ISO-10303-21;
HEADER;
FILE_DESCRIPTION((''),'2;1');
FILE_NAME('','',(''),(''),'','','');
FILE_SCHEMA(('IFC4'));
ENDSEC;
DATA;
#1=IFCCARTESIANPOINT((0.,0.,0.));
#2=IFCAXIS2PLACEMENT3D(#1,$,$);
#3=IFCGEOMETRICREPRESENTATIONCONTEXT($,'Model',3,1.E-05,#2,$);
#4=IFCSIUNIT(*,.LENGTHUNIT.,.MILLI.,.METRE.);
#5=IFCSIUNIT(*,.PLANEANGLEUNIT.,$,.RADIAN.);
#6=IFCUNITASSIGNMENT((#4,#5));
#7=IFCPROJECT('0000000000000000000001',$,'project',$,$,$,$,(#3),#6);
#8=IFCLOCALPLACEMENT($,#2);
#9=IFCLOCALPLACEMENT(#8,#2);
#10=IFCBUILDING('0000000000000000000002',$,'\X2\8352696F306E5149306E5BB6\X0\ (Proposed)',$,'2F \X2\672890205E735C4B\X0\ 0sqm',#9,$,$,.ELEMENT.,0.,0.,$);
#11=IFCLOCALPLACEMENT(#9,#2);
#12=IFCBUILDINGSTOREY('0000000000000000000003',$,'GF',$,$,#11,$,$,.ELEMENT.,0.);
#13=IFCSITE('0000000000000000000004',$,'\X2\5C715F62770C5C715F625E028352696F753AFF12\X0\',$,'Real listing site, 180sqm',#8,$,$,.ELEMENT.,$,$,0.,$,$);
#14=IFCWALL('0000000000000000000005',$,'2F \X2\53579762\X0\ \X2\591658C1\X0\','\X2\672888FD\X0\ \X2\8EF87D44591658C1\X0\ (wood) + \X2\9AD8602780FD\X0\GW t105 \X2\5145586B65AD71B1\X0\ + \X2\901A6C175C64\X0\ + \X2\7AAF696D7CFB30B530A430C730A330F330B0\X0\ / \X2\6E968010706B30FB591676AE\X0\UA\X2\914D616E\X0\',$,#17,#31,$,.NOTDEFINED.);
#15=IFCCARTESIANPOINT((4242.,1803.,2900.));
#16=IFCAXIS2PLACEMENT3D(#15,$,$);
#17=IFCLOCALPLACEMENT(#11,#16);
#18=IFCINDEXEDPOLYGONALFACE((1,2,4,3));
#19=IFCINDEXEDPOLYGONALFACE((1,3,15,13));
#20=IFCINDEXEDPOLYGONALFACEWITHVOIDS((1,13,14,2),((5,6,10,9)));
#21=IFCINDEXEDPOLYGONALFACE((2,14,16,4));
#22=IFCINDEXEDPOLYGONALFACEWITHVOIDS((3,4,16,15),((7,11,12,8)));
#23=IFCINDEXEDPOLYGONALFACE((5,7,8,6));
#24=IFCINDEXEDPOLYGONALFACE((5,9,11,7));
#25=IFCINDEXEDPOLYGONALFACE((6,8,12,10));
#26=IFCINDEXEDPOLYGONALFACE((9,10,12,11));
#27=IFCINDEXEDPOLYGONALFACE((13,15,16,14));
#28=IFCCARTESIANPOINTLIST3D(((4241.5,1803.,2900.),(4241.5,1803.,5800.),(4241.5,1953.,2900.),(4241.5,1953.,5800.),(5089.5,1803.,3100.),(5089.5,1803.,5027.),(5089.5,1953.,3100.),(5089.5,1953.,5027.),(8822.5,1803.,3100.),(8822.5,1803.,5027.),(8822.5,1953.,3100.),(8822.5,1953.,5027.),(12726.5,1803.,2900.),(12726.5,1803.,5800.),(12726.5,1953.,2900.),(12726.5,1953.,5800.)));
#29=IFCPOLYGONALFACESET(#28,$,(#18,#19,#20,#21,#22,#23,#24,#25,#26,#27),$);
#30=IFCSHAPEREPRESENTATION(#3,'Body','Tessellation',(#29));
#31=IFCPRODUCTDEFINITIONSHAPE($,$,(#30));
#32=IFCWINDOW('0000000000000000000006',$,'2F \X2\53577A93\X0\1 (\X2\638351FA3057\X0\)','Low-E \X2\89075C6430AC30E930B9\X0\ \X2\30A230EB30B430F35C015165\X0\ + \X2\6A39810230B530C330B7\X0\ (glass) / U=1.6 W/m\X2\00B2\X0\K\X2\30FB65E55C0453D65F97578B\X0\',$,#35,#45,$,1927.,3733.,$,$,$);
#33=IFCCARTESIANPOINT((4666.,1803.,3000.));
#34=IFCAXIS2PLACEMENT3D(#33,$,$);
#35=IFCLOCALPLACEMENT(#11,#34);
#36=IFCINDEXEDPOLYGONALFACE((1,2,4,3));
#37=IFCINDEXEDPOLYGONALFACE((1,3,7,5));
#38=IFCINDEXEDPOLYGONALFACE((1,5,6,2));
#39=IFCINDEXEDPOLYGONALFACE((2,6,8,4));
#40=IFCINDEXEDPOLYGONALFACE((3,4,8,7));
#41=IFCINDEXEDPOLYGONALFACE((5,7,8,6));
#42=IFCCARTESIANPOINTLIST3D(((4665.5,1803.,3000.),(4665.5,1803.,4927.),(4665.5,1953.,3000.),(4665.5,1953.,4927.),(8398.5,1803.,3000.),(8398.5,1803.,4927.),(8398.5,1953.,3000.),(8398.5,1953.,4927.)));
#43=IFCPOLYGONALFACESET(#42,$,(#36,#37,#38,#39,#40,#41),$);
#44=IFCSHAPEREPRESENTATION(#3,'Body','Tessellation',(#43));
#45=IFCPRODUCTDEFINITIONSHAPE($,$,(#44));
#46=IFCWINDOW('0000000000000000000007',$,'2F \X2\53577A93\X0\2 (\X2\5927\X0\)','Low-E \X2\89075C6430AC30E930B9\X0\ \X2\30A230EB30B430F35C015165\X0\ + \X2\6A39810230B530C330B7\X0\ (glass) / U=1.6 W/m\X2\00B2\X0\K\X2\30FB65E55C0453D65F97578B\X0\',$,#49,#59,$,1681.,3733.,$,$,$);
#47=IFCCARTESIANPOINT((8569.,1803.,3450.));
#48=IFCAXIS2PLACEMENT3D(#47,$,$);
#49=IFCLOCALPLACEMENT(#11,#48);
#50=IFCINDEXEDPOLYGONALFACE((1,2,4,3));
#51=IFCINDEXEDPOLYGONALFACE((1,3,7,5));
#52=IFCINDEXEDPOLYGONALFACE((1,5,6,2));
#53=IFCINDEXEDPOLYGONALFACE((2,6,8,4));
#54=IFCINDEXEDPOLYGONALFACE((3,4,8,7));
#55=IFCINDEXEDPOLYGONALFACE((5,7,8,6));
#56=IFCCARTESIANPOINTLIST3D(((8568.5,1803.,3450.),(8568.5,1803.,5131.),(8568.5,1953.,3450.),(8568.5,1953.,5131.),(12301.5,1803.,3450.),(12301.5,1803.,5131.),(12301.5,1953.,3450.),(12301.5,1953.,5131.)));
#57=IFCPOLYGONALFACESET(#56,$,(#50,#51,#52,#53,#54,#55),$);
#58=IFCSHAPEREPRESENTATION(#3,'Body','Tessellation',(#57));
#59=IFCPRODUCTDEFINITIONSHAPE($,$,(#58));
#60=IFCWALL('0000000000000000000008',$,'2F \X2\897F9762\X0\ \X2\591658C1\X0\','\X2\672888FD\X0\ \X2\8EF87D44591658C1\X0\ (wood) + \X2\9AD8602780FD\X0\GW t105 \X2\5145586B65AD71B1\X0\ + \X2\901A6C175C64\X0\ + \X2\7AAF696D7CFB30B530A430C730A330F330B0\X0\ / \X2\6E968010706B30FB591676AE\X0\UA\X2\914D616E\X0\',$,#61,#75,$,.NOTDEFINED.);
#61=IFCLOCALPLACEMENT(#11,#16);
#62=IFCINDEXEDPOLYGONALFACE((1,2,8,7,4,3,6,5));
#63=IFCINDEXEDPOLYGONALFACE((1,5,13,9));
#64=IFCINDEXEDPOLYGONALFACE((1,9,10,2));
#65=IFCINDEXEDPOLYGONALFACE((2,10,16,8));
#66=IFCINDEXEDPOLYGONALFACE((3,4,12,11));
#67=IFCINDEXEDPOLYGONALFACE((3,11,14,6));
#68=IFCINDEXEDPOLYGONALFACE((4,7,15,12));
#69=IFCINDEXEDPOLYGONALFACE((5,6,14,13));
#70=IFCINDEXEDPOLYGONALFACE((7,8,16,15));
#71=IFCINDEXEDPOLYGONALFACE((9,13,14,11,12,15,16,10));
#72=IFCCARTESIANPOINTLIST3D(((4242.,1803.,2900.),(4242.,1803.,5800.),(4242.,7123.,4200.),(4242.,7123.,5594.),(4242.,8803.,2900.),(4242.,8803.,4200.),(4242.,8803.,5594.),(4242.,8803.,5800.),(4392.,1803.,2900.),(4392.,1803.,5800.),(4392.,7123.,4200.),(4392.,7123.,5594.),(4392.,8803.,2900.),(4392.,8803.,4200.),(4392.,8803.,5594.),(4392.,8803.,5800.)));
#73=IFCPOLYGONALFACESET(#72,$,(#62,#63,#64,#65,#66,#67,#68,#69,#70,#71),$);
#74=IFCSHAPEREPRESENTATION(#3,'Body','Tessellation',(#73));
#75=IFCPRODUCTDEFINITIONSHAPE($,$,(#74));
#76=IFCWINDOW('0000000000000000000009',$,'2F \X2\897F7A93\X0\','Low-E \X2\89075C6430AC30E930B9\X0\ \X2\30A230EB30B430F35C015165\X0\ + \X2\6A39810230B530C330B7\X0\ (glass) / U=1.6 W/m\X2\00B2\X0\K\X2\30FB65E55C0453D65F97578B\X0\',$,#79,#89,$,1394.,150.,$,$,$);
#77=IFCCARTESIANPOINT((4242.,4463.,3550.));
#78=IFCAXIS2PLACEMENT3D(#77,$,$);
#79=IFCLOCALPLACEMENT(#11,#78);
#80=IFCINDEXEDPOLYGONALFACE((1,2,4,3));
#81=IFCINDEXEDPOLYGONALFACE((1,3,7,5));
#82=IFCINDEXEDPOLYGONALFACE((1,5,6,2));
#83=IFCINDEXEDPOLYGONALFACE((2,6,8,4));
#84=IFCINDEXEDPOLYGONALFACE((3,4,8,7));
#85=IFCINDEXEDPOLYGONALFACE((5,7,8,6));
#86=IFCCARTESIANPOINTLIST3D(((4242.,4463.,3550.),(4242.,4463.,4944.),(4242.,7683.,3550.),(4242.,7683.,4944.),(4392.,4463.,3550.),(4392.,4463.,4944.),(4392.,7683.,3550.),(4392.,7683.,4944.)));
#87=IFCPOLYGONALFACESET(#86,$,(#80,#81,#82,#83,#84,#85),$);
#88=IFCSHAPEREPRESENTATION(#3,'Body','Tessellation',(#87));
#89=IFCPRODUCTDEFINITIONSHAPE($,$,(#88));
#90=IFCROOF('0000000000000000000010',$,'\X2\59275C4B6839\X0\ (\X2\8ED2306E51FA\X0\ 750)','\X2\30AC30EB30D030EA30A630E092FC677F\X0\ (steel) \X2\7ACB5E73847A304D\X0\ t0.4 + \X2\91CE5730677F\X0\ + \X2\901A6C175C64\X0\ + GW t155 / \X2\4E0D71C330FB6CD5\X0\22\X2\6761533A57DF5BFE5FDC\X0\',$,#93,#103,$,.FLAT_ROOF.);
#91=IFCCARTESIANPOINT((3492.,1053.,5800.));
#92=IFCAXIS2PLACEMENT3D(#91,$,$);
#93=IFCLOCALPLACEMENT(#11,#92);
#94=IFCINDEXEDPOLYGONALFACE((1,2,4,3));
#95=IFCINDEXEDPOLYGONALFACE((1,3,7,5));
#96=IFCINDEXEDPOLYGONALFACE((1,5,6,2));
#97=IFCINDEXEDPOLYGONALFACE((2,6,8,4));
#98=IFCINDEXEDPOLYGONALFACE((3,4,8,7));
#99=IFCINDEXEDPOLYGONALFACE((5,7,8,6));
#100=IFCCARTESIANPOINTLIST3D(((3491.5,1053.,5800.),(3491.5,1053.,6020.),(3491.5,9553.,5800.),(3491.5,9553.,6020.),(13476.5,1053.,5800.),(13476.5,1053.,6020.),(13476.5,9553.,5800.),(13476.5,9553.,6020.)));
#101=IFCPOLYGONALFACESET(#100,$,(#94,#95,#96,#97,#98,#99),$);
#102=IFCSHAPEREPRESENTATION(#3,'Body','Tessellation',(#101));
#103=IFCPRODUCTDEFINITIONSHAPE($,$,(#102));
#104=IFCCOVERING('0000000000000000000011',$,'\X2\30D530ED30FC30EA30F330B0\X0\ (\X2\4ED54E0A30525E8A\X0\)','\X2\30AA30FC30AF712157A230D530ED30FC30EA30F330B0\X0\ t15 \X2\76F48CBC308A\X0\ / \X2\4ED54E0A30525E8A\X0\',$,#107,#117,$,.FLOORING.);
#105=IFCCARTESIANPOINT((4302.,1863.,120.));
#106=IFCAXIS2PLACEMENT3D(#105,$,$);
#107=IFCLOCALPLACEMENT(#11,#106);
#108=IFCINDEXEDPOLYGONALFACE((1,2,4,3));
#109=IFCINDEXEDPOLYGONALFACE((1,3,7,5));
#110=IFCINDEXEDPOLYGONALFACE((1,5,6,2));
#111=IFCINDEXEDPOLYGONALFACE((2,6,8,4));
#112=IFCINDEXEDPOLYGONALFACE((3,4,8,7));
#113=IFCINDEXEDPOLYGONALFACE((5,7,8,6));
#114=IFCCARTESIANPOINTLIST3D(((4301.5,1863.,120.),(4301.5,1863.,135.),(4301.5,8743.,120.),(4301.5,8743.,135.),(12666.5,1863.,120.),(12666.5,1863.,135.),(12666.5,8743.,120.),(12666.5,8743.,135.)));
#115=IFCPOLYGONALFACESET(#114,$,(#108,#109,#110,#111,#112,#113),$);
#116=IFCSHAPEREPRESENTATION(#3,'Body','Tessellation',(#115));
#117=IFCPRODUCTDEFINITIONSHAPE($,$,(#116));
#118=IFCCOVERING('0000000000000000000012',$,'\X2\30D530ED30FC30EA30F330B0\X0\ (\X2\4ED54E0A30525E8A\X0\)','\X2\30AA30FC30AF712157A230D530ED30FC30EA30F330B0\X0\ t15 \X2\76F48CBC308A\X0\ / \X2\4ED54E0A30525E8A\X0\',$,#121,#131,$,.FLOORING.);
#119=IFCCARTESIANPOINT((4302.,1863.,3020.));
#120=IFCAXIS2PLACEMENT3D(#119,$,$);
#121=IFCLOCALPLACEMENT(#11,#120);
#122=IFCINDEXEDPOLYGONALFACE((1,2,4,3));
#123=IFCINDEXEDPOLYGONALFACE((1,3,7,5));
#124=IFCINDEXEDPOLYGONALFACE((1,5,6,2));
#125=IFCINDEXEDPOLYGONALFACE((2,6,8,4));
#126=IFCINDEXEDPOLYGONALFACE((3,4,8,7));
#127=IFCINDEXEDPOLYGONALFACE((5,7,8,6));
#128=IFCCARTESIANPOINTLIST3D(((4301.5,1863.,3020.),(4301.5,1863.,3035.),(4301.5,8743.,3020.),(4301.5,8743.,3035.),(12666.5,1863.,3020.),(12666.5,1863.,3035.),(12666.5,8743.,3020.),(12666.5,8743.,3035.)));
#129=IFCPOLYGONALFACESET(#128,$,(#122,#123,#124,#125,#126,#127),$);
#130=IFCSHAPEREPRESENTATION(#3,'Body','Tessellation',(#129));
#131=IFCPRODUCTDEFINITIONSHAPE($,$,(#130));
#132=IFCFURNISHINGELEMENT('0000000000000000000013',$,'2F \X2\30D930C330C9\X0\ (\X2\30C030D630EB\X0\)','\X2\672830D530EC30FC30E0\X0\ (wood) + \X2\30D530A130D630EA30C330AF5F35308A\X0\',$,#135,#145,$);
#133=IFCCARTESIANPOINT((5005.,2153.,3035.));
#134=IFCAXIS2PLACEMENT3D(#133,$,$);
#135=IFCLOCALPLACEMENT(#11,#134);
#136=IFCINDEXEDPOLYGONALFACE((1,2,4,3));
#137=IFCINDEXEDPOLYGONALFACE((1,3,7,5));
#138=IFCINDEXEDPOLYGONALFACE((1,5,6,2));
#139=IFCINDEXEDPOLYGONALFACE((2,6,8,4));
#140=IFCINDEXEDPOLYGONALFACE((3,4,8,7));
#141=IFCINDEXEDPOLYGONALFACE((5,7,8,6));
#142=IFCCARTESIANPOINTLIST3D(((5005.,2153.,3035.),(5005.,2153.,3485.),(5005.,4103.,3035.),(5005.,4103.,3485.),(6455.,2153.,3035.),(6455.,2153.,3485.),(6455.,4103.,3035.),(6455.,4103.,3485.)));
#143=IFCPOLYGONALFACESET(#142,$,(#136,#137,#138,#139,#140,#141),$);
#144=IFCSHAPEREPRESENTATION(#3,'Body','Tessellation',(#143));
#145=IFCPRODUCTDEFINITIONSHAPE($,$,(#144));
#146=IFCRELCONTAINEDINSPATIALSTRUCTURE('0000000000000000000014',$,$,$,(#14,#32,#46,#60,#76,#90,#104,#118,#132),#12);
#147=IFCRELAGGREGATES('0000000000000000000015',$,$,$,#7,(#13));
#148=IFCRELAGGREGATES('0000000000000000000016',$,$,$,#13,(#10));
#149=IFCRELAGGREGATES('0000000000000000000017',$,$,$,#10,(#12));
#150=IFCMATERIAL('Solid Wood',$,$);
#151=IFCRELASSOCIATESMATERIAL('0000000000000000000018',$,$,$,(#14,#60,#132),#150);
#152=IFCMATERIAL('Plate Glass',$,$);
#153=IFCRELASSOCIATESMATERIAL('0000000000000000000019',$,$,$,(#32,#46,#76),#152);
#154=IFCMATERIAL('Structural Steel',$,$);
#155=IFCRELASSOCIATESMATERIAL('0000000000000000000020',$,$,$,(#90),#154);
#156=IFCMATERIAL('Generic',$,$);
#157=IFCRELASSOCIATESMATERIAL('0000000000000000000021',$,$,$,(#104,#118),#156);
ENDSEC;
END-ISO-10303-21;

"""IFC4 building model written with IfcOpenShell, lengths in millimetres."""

from ifc_helpers import new_model, si_unit, frame, frame_2d, origin, place, context, project, spatial, rectangle, extrude, material, element, fill, save


model = new_model("IFC4")

# Units and contexts
model_context = context("Model", 3, precision=1e-05, world=origin())
ifc_project = project(units=[si_unit("LENGTHUNIT", "METRE", prefix="MILLI"), si_unit("PLANEANGLEUNIT", "RADIAN")], contexts=[model_context])

# Site, building, storey
site_placement = place(None, origin())
site = spatial("IfcSite", under=ifc_project, at=site_placement, Name="山形県山形市荒楯町２", ObjectType="Real listing site, 180sqm", CompositionType="ELEMENT", RefElevation=0.0)
building_placement = place(site_placement, origin())
building = spatial("IfcBuilding", under=site, at=building_placement, Name="荒楯の光の家 (Proposed)", ObjectType="2F 木造平屋 0sqm", CompositionType="ELEMENT", ElevationOfRefHeight=0.0, ElevationOfTerrain=0.0)
storey_placement = place(building_placement, origin())
storey = spatial("IfcBuildingStorey", under=building, at=storey_placement, Name="GF", CompositionType="ELEMENT", Elevation=0.0)

# Shared definitions
ifc_material_1 = material(Name="Solid Wood")

# Shared definitions
ifc_material_2 = material(Name="Plate Glass")

# Wall, openings, windows
wall_1_placement = place(storey_placement, frame((4242.0, 1803.0, 2900.0)))
wall_1 = element("IfcWall", 1, at=wall_1_placement, inside=storey, material=ifc_material_1, Name="2F 南面 外壁", Description="木製 軸組外壁 (wood) + 高性能GW t105 充填断熱 + 通気層 + 窯業系サイディング / 準耐火・外皮UA配慮", PredefinedType="NOTDEFINED", context=model_context, shape_type="SweptSolid", body=[
    extrude(rectangle(XDim=8485.0, YDim=150.0, at=frame_2d((4242.0, 75.0))), frame((4242.0, 1803.0, 2900.0)), (0.0, 0.0, 1.0), 2900.0),
])
opening_1_placement = place(storey_placement, frame((4666.0, 1803.0, 3000.0)))
opening_1 = element("IfcOpeningElement", 2, at=opening_1_placement, cuts=wall_1, PredefinedType="NOTDEFINED", context=model_context, shape_type="SweptSolid", body=[
    extrude(rectangle(XDim=3733.0, YDim=150.0, at=frame_2d((1866.0, 75.0))), frame((4666.0, 1803.0, 3000.0)), (0.0, 0.0, 1.0), 1927.0),
])
opening_2_placement = place(storey_placement, frame((8569.0, 1803.0, 3450.0)))
opening_2 = element("IfcOpeningElement", 3, at=opening_2_placement, cuts=wall_1, PredefinedType="NOTDEFINED", context=model_context, shape_type="SweptSolid", body=[
    extrude(rectangle(XDim=3733.0, YDim=150.0, at=frame_2d((1866.0, 75.0))), frame((8569.0, 1803.0, 3450.0)), (0.0, 0.0, 1.0), 1681.0),
])
window_1_placement = place(storey_placement, frame((4666.0, 1803.0, 3000.0)))
window_1 = element("IfcWindow", 4, at=window_1_placement, inside=storey, material=ifc_material_2, Name="2F 南窓1 (掃出し)", Description="Low-E 複層ガラス アルゴン封入 + 樹脂サッシ (glass) / U=1.6 W/m²K・日射取得型", OverallHeight=1927.0, OverallWidth=3733.0, context=model_context, shape_type="SweptSolid", body=[
    extrude(rectangle(XDim=3733.0, YDim=150.0, at=frame_2d((1866.0, 75.0))), frame((4666.0, 1803.0, 3000.0)), (0.0, 0.0, 1.0), 1927.0),
])
fill(opening_1, window_1)
window_2_placement = place(storey_placement, frame((8569.0, 1803.0, 3450.0)))
window_2 = element("IfcWindow", 5, at=window_2_placement, inside=storey, material=ifc_material_2, Name="2F 南窓2 (大)", Description="Low-E 複層ガラス アルゴン封入 + 樹脂サッシ (glass) / U=1.6 W/m²K・日射取得型", OverallHeight=1681.0, OverallWidth=3733.0, context=model_context, shape_type="SweptSolid", body=[
    extrude(rectangle(XDim=3733.0, YDim=150.0, at=frame_2d((1866.0, 75.0))), frame((8569.0, 1803.0, 3450.0)), (0.0, 0.0, 1.0), 1681.0),
])
fill(opening_2, window_2)

# Wall, opening, window
wall_2_placement = place(storey_placement, frame((4242.0, 1803.0, 2900.0)))
wall_2 = element("IfcWall", 6, at=wall_2_placement, inside=storey, material=ifc_material_1, Name="2F 西面 外壁", Description="木製 軸組外壁 (wood) + 高性能GW t105 充填断熱 + 通気層 + 窯業系サイディング / 準耐火・外皮UA配慮", PredefinedType="NOTDEFINED", context=model_context, shape_type="SweptSolid", body=[
    extrude(rectangle(XDim=150.0, YDim=7000.0, at=frame_2d((75.0, 3500.0))), frame((4242.0, 1803.0, 2900.0)), (0.0, 0.0, 1.0), 2900.0),
])
opening_3_placement = place(storey_placement, frame((4242.0, 4463.0, 3550.0)))
opening_3 = element("IfcOpeningElement", 7, at=opening_3_placement, cuts=wall_2, PredefinedType="NOTDEFINED", context=model_context, shape_type="SweptSolid", body=[
    extrude(rectangle(XDim=150.0, YDim=3220.0, at=frame_2d((75.0, 1610.0))), frame((4242.0, 4463.0, 3550.0)), (0.0, 0.0, 1.0), 1394.0),
])
window_3_placement = place(storey_placement, frame((4242.0, 4463.0, 3550.0)))
window_3 = element("IfcWindow", 8, at=window_3_placement, inside=storey, material=ifc_material_2, Name="2F 西窓", Description="Low-E 複層ガラス アルゴン封入 + 樹脂サッシ (glass) / U=1.6 W/m²K・日射取得型", OverallHeight=1394.0, OverallWidth=150.0, context=model_context, shape_type="SweptSolid", body=[
    extrude(rectangle(XDim=150.0, YDim=3220.0, at=frame_2d((75.0, 1610.0))), frame((4242.0, 4463.0, 3550.0)), (0.0, 0.0, 1.0), 1394.0),
])
fill(opening_3, window_3)

# Roof
ifc_material_3 = material(Name="Structural Steel")
roof_placement = place(storey_placement, frame((3492.0, 1053.0, 5800.0)))
element("IfcRoof", 9, at=roof_placement, inside=storey, material=ifc_material_3, Name="大屋根 (軒の出 750)", Description="ガルバリウム鋼板 (steel) 立平葺き t0.4 + 野地板 + 通気層 + GW t155 / 不燃・法22条区域対応", PredefinedType="FLAT_ROOF", context=model_context, shape_type="SweptSolid", body=[
    extrude(rectangle(XDim=9985.0, YDim=8500.0, at=frame_2d((4992.0, 4250.0))), frame((3492.0, 1053.0, 5800.0)), (0.0, 0.0, 1.0), 220.0),
])

# Coverings
ifc_material_4 = material(Name="Generic")
covering_1_placement = place(storey_placement, frame((4302.0, 1863.0, 120.0)))
element("IfcCovering", 10, at=covering_1_placement, inside=storey, material=ifc_material_4, Name="フローリング (仕上げ床)", Description="オーク無垢フローリング t15 直貼り / 仕上げ床", PredefinedType="FLOORING", context=model_context, shape_type="SweptSolid", body=[
    extrude(rectangle(XDim=8365.0, YDim=6880.0, at=frame_2d((4182.0, 3440.0))), frame((4302.0, 1863.0, 120.0)), (0.0, 0.0, 1.0), 15.0),
])
covering_2_placement = place(storey_placement, frame((4302.0, 1863.0, 3020.0)))
element("IfcCovering", 11, at=covering_2_placement, inside=storey, material=ifc_material_4, Name="フローリング (仕上げ床)", Description="オーク無垢フローリング t15 直貼り / 仕上げ床", PredefinedType="FLOORING", context=model_context, shape_type="SweptSolid", body=[
    extrude(rectangle(XDim=8365.0, YDim=6880.0, at=frame_2d((4182.0, 3440.0))), frame((4302.0, 1863.0, 3020.0)), (0.0, 0.0, 1.0), 15.0),
])

# Furnishing element
furnishing_placement = place(storey_placement, frame((5005.0, 2153.0, 3035.0)))
element("IfcFurnishingElement", 12, at=furnishing_placement, inside=storey, material=ifc_material_1, Name="2F ベッド (ダブル)", Description="木フレーム (wood) + ファブリック張り", context=model_context, shape_type="SweptSolid", body=[
    extrude(rectangle(XDim=1450.0, YDim=1950.0, at=frame_2d((725.0, 975.0))), frame((5005.0, 2153.0, 3035.0)), (0.0, 0.0, 1.0), 450.0),
])

save(model, "model.ifc")
